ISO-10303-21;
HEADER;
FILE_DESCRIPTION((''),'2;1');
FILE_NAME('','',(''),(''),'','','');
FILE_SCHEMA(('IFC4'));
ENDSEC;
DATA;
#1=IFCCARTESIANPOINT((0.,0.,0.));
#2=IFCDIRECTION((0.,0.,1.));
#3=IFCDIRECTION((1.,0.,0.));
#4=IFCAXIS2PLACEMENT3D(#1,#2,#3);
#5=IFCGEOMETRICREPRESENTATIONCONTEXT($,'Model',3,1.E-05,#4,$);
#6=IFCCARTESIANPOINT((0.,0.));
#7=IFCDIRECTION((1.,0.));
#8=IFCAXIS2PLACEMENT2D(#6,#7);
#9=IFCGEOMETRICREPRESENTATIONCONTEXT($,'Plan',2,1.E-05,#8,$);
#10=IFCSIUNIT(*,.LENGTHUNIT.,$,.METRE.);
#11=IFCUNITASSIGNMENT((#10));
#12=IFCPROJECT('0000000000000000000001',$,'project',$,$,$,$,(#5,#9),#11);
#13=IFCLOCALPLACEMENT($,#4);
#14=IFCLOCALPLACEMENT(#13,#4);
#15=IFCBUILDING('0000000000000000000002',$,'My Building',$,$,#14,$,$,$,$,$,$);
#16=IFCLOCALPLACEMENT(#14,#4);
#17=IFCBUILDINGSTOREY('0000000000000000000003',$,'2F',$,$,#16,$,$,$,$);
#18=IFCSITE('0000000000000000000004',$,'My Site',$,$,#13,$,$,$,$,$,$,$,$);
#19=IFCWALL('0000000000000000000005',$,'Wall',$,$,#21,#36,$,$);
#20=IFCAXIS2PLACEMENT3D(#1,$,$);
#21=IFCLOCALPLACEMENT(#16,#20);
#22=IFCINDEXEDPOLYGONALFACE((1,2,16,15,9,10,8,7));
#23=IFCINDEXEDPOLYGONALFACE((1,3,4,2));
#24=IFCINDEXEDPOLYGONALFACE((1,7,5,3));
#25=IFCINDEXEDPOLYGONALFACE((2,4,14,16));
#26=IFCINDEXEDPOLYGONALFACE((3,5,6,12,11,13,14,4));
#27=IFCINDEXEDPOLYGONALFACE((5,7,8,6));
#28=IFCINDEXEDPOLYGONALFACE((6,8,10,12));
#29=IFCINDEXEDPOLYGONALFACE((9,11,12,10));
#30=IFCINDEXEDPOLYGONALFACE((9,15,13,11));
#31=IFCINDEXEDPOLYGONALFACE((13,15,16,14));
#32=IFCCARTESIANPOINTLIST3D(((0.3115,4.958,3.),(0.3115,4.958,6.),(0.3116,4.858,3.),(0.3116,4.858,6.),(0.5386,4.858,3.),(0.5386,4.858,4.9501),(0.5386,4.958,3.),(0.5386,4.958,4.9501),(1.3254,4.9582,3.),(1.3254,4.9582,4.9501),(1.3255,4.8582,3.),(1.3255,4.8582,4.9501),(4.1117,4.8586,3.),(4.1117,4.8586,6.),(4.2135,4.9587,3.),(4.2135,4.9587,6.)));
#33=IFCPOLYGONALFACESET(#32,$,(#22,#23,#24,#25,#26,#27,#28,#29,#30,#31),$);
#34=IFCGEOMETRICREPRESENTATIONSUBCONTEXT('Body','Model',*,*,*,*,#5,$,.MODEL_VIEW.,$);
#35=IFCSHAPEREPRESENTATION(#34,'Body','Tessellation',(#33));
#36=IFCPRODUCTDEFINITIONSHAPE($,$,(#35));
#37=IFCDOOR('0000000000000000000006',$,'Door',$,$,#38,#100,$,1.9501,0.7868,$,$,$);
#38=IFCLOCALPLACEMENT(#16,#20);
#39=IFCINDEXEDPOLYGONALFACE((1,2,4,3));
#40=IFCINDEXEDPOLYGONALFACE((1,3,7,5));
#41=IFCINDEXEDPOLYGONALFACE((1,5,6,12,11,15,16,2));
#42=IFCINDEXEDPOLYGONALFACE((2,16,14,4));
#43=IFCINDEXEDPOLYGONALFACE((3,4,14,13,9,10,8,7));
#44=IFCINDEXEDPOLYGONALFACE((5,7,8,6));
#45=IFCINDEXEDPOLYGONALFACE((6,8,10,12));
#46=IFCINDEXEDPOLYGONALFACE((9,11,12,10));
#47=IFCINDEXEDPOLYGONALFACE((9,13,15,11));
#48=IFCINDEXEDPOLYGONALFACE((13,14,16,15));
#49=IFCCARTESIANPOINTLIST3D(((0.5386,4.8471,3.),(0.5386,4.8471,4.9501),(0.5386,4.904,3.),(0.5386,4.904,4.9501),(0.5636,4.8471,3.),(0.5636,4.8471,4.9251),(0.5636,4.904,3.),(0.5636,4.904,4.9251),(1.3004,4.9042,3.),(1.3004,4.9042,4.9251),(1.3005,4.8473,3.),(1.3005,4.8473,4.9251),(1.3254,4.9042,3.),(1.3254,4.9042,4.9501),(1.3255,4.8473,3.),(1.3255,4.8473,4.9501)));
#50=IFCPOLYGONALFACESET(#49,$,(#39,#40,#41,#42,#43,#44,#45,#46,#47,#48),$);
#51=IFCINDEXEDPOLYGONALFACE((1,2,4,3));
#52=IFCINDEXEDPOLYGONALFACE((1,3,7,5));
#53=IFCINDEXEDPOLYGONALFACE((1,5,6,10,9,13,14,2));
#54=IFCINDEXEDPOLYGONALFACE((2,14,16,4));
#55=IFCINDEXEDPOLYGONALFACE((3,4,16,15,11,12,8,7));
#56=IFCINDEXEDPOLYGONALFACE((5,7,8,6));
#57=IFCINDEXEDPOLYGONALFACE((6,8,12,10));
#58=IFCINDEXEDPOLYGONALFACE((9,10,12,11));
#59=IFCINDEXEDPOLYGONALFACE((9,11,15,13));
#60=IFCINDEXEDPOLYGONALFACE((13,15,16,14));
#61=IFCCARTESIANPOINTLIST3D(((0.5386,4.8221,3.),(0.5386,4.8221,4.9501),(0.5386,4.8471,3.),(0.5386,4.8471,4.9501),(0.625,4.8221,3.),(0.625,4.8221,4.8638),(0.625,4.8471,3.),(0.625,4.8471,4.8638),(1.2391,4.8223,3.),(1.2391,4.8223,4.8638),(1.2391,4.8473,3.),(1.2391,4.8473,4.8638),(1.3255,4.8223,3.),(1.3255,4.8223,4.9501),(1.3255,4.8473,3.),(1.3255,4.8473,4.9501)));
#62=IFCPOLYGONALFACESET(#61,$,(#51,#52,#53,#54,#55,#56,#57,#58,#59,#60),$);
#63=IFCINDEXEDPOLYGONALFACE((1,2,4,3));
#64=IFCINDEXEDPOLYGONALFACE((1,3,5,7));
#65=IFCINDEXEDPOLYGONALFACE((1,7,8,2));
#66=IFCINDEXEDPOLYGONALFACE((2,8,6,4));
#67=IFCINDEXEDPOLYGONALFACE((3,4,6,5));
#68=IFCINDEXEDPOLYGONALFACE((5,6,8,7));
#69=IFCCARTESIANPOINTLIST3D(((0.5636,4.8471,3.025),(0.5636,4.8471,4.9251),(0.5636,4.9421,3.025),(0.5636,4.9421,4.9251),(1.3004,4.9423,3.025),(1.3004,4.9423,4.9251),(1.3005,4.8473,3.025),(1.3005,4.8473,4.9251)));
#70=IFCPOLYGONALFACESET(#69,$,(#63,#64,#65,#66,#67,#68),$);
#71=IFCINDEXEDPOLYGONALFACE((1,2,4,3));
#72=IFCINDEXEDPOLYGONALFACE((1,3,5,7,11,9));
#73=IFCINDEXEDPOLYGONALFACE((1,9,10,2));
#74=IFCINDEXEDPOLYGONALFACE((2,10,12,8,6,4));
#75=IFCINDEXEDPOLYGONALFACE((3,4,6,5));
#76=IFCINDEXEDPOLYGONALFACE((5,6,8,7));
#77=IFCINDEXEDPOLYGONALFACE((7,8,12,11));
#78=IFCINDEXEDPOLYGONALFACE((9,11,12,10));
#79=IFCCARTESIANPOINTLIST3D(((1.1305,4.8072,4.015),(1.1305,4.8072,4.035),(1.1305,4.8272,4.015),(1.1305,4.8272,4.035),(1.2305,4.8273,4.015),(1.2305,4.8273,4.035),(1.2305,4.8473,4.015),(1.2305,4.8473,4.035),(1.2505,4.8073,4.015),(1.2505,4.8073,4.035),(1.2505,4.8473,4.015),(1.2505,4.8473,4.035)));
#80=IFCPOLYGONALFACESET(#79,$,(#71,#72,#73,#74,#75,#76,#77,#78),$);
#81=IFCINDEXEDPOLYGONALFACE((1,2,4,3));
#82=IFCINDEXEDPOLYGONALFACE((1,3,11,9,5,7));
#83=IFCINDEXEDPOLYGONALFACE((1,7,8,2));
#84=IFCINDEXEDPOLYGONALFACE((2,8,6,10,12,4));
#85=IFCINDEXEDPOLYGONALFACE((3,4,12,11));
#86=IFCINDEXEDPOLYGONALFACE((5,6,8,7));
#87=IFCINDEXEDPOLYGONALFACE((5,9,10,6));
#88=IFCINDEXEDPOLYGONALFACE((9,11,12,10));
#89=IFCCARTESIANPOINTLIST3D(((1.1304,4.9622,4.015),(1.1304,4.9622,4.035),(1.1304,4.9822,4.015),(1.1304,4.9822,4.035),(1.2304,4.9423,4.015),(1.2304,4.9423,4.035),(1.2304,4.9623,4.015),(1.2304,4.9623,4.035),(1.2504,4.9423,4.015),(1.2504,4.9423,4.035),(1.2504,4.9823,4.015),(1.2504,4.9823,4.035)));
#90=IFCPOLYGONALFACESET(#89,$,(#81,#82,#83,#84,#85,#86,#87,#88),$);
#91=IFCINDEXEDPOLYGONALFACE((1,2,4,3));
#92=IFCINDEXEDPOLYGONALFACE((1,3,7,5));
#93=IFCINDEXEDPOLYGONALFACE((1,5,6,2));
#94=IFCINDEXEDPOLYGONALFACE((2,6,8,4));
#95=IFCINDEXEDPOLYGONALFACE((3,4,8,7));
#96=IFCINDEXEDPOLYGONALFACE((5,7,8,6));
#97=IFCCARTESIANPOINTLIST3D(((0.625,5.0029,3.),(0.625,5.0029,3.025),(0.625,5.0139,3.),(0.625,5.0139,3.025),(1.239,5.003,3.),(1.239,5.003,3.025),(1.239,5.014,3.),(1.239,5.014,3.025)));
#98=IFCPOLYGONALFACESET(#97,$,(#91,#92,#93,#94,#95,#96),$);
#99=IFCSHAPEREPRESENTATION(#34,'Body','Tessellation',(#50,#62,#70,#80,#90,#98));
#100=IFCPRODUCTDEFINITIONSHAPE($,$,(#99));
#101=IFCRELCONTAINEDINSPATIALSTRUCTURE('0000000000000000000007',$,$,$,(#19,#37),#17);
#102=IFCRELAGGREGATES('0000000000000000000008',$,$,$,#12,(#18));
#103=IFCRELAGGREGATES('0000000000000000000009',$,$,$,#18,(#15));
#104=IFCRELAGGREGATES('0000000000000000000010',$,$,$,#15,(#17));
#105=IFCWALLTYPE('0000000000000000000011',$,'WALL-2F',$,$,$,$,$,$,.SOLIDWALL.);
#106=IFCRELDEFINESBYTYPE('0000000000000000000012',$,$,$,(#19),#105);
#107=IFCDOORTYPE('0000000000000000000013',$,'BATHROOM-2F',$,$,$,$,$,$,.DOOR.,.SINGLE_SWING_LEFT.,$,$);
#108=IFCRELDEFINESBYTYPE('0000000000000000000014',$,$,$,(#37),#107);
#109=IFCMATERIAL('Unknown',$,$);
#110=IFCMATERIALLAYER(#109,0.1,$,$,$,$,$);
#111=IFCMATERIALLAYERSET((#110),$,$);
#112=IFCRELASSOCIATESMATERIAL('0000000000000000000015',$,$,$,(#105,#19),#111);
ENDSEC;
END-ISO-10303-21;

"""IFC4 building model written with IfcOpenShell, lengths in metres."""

from ifc_helpers import new_model, entity, si_unit, frame, origin_with_axes, origin_2d_with_axis, place, context, subcontext, project, spatial, line, indexed_curve, outline, extrude, shape, source, transform, mapped, material, layer, layer_set, layer_usage, type_object, type_shapes, element, fill, save


model = new_model("IFC4")

# Units and contexts
model_context = context("Model", 3, precision=1e-05, world=origin_with_axes())
plan_context = context("Plan", 2, precision=1e-05, world=origin_2d_with_axis())
body_context_1 = subcontext(model_context, "Body", "Model", "MODEL_VIEW")
body_context_2 = subcontext(plan_context, "Body", "Plan", "PLAN_VIEW")
ifc_project = project(units=[si_unit("LENGTHUNIT", "METRE")], contexts=[model_context, plan_context])

# Site, building, storey
site_placement = place(None, origin_with_axes())
site = spatial("IfcSite", under=ifc_project, at=site_placement, Name="My Site")
building_placement = place(site_placement, origin_with_axes())
building = spatial("IfcBuilding", under=site, at=building_placement, Name="My Building")
storey_placement = place(building_placement, origin_with_axes())
storey = spatial("IfcBuildingStorey", under=building, at=storey_placement, Name="2F")

# Shared definitions
ifc_material = material(Name="Unknown")
ifc_layer_1 = layer(ifc_material, 0.1)
ifc_layer_set_1 = layer_set([ifc_layer_1])
wall_type_1 = type_object("IfcWallType", Name="WALL-2F", PredefinedType="SOLIDWALL", material=ifc_layer_set_1)

# Wall, opening, door
ifc_layer_usage_1 = layer_usage(ifc_layer_set_1, "AXIS2", "POSITIVE", 0.0)
wall_1_placement = place(storey_placement, frame((4.2135, 4.9587, 3.0), z_axis=(0.0, 0.0, 1.0), x_axis=(-1.0, -0.000176, 0.0)))
wall_1 = element("IfcWall", 1, at=wall_1_placement, inside=storey, type_object=wall_type_1, material=ifc_layer_usage_1, Name="Wall", context=body_context_1, shape_type="SweptSolid", body=[
    extrude(outline(indexed_curve([(0.0, 0.0), (0.1018, 0.1), (3.9019, 0.1), (3.9019, 0.0)], segments=[line(1, 2, 3, 4, 1)])), origin_with_axes(), (0.0, 0.0, 1.0), 3.0),
])
shared_shape_1 = source(origin_with_axes(), body_context_1, "Body", "SweptSolid", [
    extrude(outline(indexed_curve([(0.0, 0.0), (0.7868, 0.0), (0.7868, 1.9501), (0.0, 1.9501)], segments=[line(1, 2, 3, 4, 1)])), frame((0.0, -0.6, 0.0), z_axis=(0.0, -1.0, 0.0), x_axis=(1.0, 0.0, 0.0)), (0.0, 0.0, -1.0), 1.2),
])
opening_1_placement = place(wall_1_placement, frame((3.6749, 0.1, 0.0), z_axis=(0.0, 0.0, 1.0), x_axis=(-1.0, 0.0, 0.0)))
opening_1 = element("IfcOpeningElement", 2, at=opening_1_placement, cuts=wall_1, PredefinedType="OPENING", context=body_context_1, shape_type="MappedRepresentation", body=[
    mapped(shared_shape_1, transform((0.0, 0.0, 0.0), x_axis=(1.0, 0.0, 0.0), y_axis=(0.0, 1.0, 0.0), z_axis=(0.0, 0.0, 1.0), scale=1.0)),
])
door_type_1 = type_object("IfcDoorType", Name="BATHROOM-2F", OperationType="SINGLE_SWING_LEFT", PredefinedType="DOOR")
shared_shape_2 = source(origin_with_axes(), body_context_1, "Body", "SweptSolid", [
    extrude(outline(indexed_curve([(0.0, 0.0), (0.0, 1.9501), (0.7868, 1.9501), (0.7868, 0.0), (0.7618, 0.0), (0.7618, 1.9251), (0.025, 1.9251), (0.025, 0.0)], segments=[line(1, 2, 3, 4, 5, 6, 7, 8, 1)])), frame((0.0, 0.0093, 0.0), z_axis=(0.0, -1.0, 0.0), x_axis=(1.0, 0.0, 0.0)), (0.0, 0.0, -1.0), 0.0569),
    extrude(outline(indexed_curve([(0.0, 0.0), (0.0, 1.9501), (0.7868, 1.9501), (0.7868, 0.0), (0.7005, 0.0), (0.7005, 1.8638), (0.0864, 1.8638), (0.0864, 0.0)], segments=[line(1, 2, 3, 4, 5, 6, 7, 8, 1)])), frame((0.0, -0.0157, 0.0), z_axis=(0.0, -1.0, 0.0), x_axis=(1.0, 0.0, 0.0)), (0.0, 0.0, -1.0), 0.025),
    extrude(outline(indexed_curve([(0.0, 0.0), (0.7368, 0.0), (0.7368, 0.095), (0.0, 0.095)], segments=[line(1, 2, 3, 4, 1)])), frame((0.025, 0.0093, 0.025), z_axis=(0.0, 0.0, 1.0), x_axis=(1.0, 0.0, 0.0)), (0.0, 0.0, 1.0), 1.9001),
    extrude(outline(indexed_curve([(0.0, 0.0), (0.0, -0.04), (-0.12, -0.04), (-0.12, -0.02), (-0.02, -0.02), (-0.02, 0.0)], segments=[line(1, 2, 3, 4, 5, 6, 1)])), frame((0.7118, 0.0093, 1.015), z_axis=(0.0, 0.0, 1.0), x_axis=(1.0, 0.0, 0.0)), (0.0, 0.0, 1.0), 0.02),
    extrude(outline(indexed_curve([(0.0, 0.0), (0.0, 0.04), (-0.12, 0.04), (-0.12, 0.02), (-0.02, 0.02), (-0.02, 0.0)], segments=[line(1, 2, 3, 4, 5, 6, 1)])), frame((0.7118, 0.1043, 1.015), z_axis=(0.0, 0.0, 1.0), x_axis=(1.0, 0.0, 0.0)), (0.0, 0.0, 1.0), 0.02),
    extrude(outline(indexed_curve([(0.0, 0.0), (0.6141, 0.0), (0.6141, 0.011), (0.0, 0.011)], segments=[line(1, 2, 3, 4, 1)])), frame((0.0864, 0.165, 0.0), z_axis=(0.0, 0.0, 1.0), x_axis=(1.0, 0.0, 0.0)), (0.0, 0.0, 1.0), 0.025),
])
shared_shape_3 = source(origin_with_axes(), body_context_2, "Body", "Curve2D", [
    entity("IfcIndexedPolyCurve", entity("IfcCartesianPointList2D", [[0.0, -0.0157], [0.0, 0.0662], [0.025, 0.0662], [0.025, 0.0093], [0.0864, 0.0093], [0.0864, -0.0157]]), [entity("IfcLineIndex", [1, 2, 3, 4, 5, 6, 1])]),
    entity("IfcIndexedPolyCurve", entity("IfcCartesianPointList2D", [[0.7868, -0.0157], [0.7868, 0.0662], [0.7618, 0.0662], [0.7618, 0.0093], [0.7005, 0.0093], [0.7005, -0.0157]]), [entity("IfcLineIndex", [1, 2, 3, 4, 5, 6, 1])]),
    entity("IfcTrimmedCurve", entity("IfcEllipse", entity("IfcAxis2Placement2D", entity("IfcCartesianPoint", [0.12, 0.0662]), entity("IfcDirection", [1.0, 0.0])), 0.6418, 0.7368), [entity("IfcCartesianPoint", [0.7618, 0.0662])], [entity("IfcCartesianPoint", [0.12, 0.803])], True, "CARTESIAN"),
    entity("IfcIndexedPolyCurve", entity("IfcCartesianPointList2D", [[0.025, 0.0662], [0.12, 0.0662], [0.12, 0.803], [0.025, 0.803]]), [entity("IfcLineIndex", [1, 2, 3, 4, 1])]),
])
type_shapes(door_type_1, [shared_shape_2, shared_shape_3])
door_1_placement = place(opening_1_placement, frame((0.0, -0.0202, 0.0), z_axis=(0.0, 0.0, 1.0), x_axis=(1.0, 0.0, 0.0)))
door_1 = element("IfcDoor", 3, at=door_1_placement, inside=storey, type_object=door_type_1, Name="Door", OverallHeight=1.9501, OverallWidth=0.7868, shapes=[
    shape(body_context_1, "Body", "MappedRepresentation", [mapped(shared_shape_2, transform((0.0, 0.0, 0.0), x_axis=(1.0, 0.0, 0.0), y_axis=(0.0, 1.0, 0.0), z_axis=(0.0, 0.0, 1.0), scale=1.0))]),
    shape(body_context_2, "Body", "MappedRepresentation", [mapped(shared_shape_3, transform((0.0, 0.0, 0.0), x_axis=(1.0, 0.0, 0.0), y_axis=(0.0, 1.0, 0.0), z_axis=(0.0, 0.0, 1.0), scale=1.0))]),
])
fill(opening_1, door_1)

save(model, "model.ifc")
